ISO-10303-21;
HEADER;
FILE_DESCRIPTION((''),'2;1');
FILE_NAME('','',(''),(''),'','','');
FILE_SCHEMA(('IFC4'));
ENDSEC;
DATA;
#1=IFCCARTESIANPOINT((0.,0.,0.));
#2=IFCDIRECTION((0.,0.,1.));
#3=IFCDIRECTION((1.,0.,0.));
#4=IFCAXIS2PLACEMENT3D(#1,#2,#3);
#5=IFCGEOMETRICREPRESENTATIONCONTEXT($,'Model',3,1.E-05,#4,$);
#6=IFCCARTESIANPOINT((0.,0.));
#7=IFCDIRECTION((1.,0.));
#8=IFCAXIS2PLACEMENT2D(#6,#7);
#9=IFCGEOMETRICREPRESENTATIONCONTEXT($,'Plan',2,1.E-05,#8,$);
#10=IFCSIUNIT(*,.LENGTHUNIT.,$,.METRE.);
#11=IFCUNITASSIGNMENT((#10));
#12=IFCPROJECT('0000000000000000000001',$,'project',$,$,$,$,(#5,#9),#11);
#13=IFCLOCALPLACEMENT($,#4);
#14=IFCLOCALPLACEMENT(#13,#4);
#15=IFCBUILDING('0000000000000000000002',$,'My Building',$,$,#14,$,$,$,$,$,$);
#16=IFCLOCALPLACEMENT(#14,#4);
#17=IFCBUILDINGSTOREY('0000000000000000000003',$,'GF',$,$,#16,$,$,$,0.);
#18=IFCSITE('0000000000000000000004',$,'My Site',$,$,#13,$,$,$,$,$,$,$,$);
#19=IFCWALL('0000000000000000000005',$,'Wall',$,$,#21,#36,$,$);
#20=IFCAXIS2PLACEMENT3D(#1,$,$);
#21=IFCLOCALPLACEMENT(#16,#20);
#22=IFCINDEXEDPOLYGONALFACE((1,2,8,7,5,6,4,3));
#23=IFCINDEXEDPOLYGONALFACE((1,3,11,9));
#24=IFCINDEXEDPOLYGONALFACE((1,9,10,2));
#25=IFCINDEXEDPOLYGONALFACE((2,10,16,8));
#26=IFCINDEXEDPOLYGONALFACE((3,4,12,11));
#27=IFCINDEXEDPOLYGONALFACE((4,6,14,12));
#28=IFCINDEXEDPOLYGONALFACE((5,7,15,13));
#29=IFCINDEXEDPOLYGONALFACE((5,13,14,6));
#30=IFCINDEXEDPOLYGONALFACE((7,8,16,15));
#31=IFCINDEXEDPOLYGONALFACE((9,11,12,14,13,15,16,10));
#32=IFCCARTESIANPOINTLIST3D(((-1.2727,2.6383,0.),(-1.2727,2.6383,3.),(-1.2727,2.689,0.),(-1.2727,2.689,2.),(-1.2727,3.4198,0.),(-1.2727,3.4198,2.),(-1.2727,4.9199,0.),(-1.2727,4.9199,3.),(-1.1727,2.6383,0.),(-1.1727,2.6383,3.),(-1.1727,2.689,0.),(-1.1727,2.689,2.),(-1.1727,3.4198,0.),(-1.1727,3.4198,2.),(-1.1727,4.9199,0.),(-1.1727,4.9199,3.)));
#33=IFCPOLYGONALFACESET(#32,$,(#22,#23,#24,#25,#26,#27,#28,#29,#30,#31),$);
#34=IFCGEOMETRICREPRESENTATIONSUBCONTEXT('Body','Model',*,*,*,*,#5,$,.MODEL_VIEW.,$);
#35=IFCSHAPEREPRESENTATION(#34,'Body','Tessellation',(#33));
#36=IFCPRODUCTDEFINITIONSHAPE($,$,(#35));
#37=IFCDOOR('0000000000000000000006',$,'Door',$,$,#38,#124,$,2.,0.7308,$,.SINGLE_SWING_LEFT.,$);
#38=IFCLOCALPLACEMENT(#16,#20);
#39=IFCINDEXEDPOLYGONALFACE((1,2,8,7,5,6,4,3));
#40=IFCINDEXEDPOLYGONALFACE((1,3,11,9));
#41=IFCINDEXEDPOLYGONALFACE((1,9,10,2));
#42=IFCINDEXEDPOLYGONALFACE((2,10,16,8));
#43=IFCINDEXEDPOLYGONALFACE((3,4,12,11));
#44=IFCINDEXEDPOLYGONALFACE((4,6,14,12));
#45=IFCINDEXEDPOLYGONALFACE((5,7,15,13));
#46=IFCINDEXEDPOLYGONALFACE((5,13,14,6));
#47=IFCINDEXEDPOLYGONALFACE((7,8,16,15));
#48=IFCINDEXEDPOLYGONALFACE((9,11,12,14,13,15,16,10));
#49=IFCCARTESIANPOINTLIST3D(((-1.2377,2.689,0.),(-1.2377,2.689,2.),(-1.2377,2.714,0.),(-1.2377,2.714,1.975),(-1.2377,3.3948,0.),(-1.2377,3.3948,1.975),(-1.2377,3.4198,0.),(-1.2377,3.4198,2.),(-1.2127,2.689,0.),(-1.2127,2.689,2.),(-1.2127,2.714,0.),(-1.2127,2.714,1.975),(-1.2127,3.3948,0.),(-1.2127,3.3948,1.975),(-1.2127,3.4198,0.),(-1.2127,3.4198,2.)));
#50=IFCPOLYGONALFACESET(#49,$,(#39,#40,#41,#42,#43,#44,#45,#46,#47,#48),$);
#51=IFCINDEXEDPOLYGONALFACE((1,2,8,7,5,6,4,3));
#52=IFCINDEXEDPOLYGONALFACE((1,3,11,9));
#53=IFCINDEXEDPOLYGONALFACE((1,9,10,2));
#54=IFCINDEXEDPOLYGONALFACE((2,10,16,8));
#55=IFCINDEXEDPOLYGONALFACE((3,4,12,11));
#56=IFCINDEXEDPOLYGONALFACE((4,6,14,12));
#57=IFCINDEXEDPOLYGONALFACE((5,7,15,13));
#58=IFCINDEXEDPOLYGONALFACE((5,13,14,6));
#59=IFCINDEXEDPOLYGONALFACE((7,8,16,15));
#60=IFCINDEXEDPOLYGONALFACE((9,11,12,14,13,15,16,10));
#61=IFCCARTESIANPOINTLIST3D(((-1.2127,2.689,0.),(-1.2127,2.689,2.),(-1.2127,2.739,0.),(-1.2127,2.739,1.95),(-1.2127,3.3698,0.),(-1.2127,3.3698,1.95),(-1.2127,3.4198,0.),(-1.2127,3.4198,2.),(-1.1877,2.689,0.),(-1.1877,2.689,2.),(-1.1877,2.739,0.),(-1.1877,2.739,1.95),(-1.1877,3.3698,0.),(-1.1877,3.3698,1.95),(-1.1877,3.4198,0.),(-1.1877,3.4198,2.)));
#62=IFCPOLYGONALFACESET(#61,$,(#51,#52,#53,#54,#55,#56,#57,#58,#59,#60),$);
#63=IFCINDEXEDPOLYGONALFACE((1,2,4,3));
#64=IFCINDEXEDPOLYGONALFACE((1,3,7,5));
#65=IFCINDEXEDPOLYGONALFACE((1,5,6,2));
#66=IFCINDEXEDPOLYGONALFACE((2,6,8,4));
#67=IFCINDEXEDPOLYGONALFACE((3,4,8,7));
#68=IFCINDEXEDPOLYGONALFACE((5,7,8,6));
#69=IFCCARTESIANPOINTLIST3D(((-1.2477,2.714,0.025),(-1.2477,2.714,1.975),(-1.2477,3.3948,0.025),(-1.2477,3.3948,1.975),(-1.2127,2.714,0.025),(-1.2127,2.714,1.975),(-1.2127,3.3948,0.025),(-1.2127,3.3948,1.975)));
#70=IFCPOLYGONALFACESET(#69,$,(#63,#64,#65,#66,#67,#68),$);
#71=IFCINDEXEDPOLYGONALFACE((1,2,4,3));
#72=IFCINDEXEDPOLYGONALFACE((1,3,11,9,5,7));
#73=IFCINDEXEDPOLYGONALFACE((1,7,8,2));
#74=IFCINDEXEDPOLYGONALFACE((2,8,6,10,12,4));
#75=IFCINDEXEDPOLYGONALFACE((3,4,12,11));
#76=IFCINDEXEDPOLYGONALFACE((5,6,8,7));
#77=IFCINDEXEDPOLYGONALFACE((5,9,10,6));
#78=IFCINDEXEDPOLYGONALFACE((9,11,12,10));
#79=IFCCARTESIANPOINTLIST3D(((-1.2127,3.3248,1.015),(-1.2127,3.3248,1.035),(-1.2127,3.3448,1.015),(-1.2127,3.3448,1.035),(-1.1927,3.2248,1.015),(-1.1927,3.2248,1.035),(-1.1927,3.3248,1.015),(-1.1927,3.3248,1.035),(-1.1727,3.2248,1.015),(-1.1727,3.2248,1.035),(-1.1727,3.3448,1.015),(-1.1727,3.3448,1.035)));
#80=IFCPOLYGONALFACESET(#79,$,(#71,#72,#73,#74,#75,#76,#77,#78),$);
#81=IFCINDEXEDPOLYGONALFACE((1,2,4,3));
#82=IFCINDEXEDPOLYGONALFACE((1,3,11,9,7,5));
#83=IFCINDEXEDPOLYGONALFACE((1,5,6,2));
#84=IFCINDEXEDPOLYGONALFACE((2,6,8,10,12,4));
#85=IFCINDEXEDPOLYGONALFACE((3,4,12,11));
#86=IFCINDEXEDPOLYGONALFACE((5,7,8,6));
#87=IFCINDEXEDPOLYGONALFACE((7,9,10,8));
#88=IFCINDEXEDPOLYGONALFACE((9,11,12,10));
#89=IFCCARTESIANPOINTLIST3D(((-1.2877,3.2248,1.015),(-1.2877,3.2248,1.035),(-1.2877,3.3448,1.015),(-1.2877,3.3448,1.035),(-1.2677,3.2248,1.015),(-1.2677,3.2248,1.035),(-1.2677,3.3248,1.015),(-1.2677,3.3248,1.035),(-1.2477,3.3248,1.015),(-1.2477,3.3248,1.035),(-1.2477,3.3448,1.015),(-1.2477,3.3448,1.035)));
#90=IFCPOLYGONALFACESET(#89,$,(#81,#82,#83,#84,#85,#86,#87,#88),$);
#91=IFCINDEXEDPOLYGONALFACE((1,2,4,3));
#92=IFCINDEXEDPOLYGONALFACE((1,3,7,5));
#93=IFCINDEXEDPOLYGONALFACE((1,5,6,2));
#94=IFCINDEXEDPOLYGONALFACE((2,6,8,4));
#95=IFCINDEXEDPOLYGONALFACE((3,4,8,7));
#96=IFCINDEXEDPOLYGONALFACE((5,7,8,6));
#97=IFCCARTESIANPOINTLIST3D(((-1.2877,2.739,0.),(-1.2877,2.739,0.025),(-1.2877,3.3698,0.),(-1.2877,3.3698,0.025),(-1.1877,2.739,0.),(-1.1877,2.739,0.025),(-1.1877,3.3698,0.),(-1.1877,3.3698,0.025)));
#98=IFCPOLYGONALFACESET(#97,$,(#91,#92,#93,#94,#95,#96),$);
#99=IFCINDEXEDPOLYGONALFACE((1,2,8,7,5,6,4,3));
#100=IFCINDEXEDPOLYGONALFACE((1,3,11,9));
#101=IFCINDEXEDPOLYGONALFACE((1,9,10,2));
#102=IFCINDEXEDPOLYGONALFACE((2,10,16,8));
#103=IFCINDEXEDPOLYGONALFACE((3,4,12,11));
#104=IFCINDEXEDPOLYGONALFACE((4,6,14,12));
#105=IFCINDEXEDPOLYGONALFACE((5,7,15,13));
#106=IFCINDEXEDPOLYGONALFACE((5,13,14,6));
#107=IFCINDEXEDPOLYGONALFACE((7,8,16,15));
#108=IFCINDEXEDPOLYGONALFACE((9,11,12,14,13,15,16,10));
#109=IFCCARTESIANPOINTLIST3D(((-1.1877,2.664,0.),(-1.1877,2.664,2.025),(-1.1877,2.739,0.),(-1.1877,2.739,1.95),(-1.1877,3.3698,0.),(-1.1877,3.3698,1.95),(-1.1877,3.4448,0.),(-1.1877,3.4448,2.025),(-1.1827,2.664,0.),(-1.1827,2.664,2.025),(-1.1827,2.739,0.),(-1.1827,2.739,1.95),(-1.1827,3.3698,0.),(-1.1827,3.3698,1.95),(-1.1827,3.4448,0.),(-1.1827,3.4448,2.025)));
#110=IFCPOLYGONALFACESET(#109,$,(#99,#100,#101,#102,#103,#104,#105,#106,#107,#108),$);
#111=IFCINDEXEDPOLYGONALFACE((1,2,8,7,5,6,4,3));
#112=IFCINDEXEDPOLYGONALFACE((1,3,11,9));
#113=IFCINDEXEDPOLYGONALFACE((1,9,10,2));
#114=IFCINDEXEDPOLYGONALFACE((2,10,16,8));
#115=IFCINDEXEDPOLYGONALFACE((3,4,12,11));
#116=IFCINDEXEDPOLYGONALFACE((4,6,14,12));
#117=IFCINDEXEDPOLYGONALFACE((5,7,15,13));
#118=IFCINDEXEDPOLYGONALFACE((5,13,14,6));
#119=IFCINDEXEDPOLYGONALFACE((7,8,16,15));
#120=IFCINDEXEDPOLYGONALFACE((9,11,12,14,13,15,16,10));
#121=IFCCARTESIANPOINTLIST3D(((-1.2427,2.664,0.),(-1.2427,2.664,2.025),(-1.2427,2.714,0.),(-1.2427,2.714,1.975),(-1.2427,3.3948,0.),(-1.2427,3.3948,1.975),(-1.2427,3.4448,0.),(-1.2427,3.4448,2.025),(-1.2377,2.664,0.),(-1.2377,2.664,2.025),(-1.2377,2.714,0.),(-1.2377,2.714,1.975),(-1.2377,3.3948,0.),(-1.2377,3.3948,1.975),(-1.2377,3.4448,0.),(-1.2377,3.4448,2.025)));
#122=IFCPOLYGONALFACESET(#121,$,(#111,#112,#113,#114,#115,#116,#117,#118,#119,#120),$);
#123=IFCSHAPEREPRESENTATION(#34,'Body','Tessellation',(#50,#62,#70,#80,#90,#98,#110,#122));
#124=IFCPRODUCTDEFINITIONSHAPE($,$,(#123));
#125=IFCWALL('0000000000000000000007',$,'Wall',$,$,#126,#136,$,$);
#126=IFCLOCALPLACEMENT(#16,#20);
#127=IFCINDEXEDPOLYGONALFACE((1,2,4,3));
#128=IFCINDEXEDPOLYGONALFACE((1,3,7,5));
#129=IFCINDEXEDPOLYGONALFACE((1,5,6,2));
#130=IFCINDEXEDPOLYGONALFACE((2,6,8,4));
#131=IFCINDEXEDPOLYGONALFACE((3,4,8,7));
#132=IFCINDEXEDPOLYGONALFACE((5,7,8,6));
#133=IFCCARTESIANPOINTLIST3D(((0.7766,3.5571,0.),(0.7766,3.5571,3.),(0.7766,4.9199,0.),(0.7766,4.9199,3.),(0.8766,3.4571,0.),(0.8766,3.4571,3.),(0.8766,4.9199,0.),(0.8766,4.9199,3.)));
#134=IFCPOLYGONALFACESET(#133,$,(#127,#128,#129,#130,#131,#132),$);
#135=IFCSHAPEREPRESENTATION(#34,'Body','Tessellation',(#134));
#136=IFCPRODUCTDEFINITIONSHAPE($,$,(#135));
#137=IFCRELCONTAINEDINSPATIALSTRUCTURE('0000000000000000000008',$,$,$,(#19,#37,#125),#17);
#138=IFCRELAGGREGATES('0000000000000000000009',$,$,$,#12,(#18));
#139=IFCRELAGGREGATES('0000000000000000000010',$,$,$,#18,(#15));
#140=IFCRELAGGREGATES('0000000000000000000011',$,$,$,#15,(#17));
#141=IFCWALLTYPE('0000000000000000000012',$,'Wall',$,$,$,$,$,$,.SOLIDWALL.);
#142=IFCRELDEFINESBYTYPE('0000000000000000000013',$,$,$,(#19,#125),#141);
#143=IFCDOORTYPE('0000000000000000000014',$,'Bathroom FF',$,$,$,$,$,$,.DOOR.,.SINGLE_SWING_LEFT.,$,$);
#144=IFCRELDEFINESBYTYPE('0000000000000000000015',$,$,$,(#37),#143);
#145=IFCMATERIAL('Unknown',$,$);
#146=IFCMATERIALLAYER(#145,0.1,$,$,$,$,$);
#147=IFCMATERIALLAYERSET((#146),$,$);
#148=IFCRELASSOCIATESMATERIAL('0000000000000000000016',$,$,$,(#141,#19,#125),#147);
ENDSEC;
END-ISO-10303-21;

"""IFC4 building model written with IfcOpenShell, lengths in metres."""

from ifc_helpers import new_model, entity, si_unit, frame, origin_with_axes, origin_2d_with_axis, place, context, subcontext, project, spatial, line, indexed_curve, outline, extrude, shape, source, transform, mapped, material, layer, layer_set, layer_usage, type_object, type_shapes, element, fill, save


model = new_model("IFC4")

# Units and contexts
model_context = context("Model", 3, precision=1e-05, world=origin_with_axes())
plan_context = context("Plan", 2, precision=1e-05, world=origin_2d_with_axis())
body_context_1 = subcontext(model_context, "Body", "Model", "MODEL_VIEW")
body_context_2 = subcontext(plan_context, "Body", "Plan", "PLAN_VIEW")
ifc_project = project(units=[si_unit("LENGTHUNIT", "METRE")], contexts=[model_context, plan_context])

# Site, building, storey
site_placement = place(None, origin_with_axes())
site = spatial("IfcSite", under=ifc_project, at=site_placement, Name="My Site")
building_placement = place(site_placement, origin_with_axes())
building = spatial("IfcBuilding", under=site, at=building_placement, Name="My Building")
storey_placement = place(building_placement, origin_with_axes())
storey = spatial("IfcBuildingStorey", under=building, at=storey_placement, Name="GF", Elevation=0.0)

# Shared definitions
ifc_material = material(Name="Unknown")

# Shared definitions
ifc_layer_1 = layer(ifc_material, 0.1)
ifc_layer_set_1 = layer_set([ifc_layer_1])
wall_type = type_object("IfcWallType", Name="Wall", PredefinedType="SOLIDWALL", material=ifc_layer_set_1)

# Wall, opening, door
ifc_layer_usage_1 = layer_usage(ifc_layer_set_1, "AXIS2", "POSITIVE", 0.0)
wall_1_placement = place(storey_placement, frame((-1.1727, 2.6383, 0.0), z_axis=(0.0, 0.0, 1.0), x_axis=(0.0, 1.0, 0.0)))
wall_1 = element("IfcWall", 1, at=wall_1_placement, inside=storey, type_object=wall_type, material=ifc_layer_usage_1, Name="Wall", context=body_context_1, shape_type="SweptSolid", body=[
    extrude(outline(indexed_curve([(0.0, 0.0), (0.0, 0.1), (2.2816, 0.1), (2.2816, 0.0)], segments=[line(1, 2, 3, 4, 1)])), origin_with_axes(), (0.0, 0.0, 1.0), 3.0),
])
shared_shape_1 = source(origin_with_axes(), body_context_1, "Body", "SweptSolid", [
    extrude(outline(indexed_curve([(0.0, 0.0), (0.7308, 0.0), (0.7308, 2.0), (0.0, 2.0)], segments=[line(1, 2, 3, 4, 1)])), frame((0.0, -0.6, 0.0), z_axis=(0.0, -1.0, 0.0), x_axis=(1.0, 0.0, 0.0)), (0.0, 0.0, -1.0), 1.2),
])
opening_1_placement = place(wall_1_placement, frame((0.0507, 0.015, 0.0), z_axis=(0.0, 0.0, 1.0), x_axis=(1.0, 0.0, 0.0)))
opening_1 = element("IfcOpeningElement", 2, at=opening_1_placement, cuts=wall_1, PredefinedType="OPENING", context=body_context_1, shape_type="MappedRepresentation", body=[
    mapped(shared_shape_1, transform((0.0, 0.0, 0.0), x_axis=(1.0, 0.0, 0.0), y_axis=(0.0, 1.0, 0.0), z_axis=(0.0, 0.0, 1.0), scale=1.0)),
])
door_type_1 = type_object("IfcDoorType", Name="Bathroom FF", OperationType="SINGLE_SWING_LEFT", PredefinedType="DOOR")
shared_shape_2 = source(origin_with_axes(), body_context_1, "Body", "SweptSolid", [
    extrude(outline(indexed_curve([(0.0, 0.0), (0.0, 2.0), (0.7308, 2.0), (0.7308, 0.0), (0.7058, 0.0), (0.7058, 1.975), (0.025, 1.975), (0.025, 0.0)], segments=[line(1, 2, 3, 4, 5, 6, 7, 8, 1)])), frame((0.0, 0.025, 0.0), z_axis=(0.0, -1.0, 0.0), x_axis=(1.0, 0.0, 0.0)), (0.0, 0.0, -1.0), 0.025),
    extrude(outline(indexed_curve([(0.0, 0.0), (0.0, 2.0), (0.7308, 2.0), (0.7308, 0.0), (0.6808, 0.0), (0.6808, 1.95), (0.05, 1.95), (0.05, 0.0)], segments=[line(1, 2, 3, 4, 5, 6, 7, 8, 1)])), frame((0.0, 0.0, 0.0), z_axis=(0.0, -1.0, 0.0), x_axis=(1.0, 0.0, 0.0)), (0.0, 0.0, -1.0), 0.025),
    extrude(outline(indexed_curve([(0.0, 0.0), (0.6808, 0.0), (0.6808, 0.035), (0.0, 0.035)], segments=[line(1, 2, 3, 4, 1)])), frame((0.025, 0.025, 0.025), z_axis=(0.0, 0.0, 1.0), x_axis=(1.0, 0.0, 0.0)), (0.0, 0.0, 1.0), 1.95),
    extrude(outline(indexed_curve([(0.0, 0.0), (0.0, -0.04), (-0.12, -0.04), (-0.12, -0.02), (-0.02, -0.02), (-0.02, 0.0)], segments=[line(1, 2, 3, 4, 5, 6, 1)])), frame((0.6558, 0.025, 1.015), z_axis=(0.0, 0.0, 1.0), x_axis=(1.0, 0.0, 0.0)), (0.0, 0.0, 1.0), 0.02),
    extrude(outline(indexed_curve([(0.0, 0.0), (0.0, 0.04), (-0.12, 0.04), (-0.12, 0.02), (-0.02, 0.02), (-0.02, 0.0)], segments=[line(1, 2, 3, 4, 5, 6, 1)])), frame((0.6558, 0.06, 1.015), z_axis=(0.0, 0.0, 1.0), x_axis=(1.0, 0.0, 0.0)), (0.0, 0.0, 1.0), 0.02),
    extrude(outline(indexed_curve([(0.0, 0.0), (0.6308, 0.0), (0.6308, 0.1), (0.0, 0.1)], segments=[line(1, 2, 3, 4, 1)])), frame((0.05, 0.0, 0.0), z_axis=(0.0, 0.0, 1.0), x_axis=(1.0, 0.0, 0.0)), (0.0, 0.0, 1.0), 0.025),
    extrude(outline(indexed_curve([(0.0, 0.0), (0.0, 2.025), (0.7808, 2.025), (0.7808, 0.0), (0.7058, 0.0), (0.7058, 1.95), (0.075, 1.95), (0.075, 0.0)], segments=[line(1, 2, 3, 4, 5, 6, 7, 8, 1)])), frame((-0.025, -0.005, 0.0), z_axis=(0.0, -1.0, 0.0), x_axis=(1.0, 0.0, 0.0)), (0.0, 0.0, -1.0), 0.005),
    extrude(outline(indexed_curve([(0.0, 0.0), (0.0, 2.025), (0.7808, 2.025), (0.7808, 0.0), (0.7308, 0.0), (0.7308, 1.975), (0.05, 1.975), (0.05, 0.0)], segments=[line(1, 2, 3, 4, 5, 6, 7, 8, 1)])), frame((-0.025, 0.05, 0.0), z_axis=(0.0, -1.0, 0.0), x_axis=(1.0, 0.0, 0.0)), (0.0, 0.0, -1.0), 0.005),
])
shared_shape_3 = source(origin_with_axes(), body_context_2, "Body", "Curve2D", [
    entity("IfcIndexedPolyCurve", entity("IfcCartesianPointList2D", [[0.0, 0.0], [0.0, 0.05], [0.025, 0.05], [0.025, 0.025], [0.05, 0.025], [0.05, 0.0]]), [entity("IfcLineIndex", [1, 2, 3, 4, 5, 6, 1])]),
    entity("IfcIndexedPolyCurve", entity("IfcCartesianPointList2D", [[0.7308, 0.0], [0.7308, 0.05], [0.7058, 0.05], [0.7058, 0.025], [0.6808, 0.025], [0.6808, 0.0]]), [entity("IfcLineIndex", [1, 2, 3, 4, 5, 6, 1])]),
    entity("IfcTrimmedCurve", entity("IfcEllipse", entity("IfcAxis2Placement2D", entity("IfcCartesianPoint", [0.06, 0.05]), entity("IfcDirection", [1.0, 0.0])), 0.6458, 0.6808), [entity("IfcCartesianPoint", [0.7058, 0.05])], [entity("IfcCartesianPoint", [0.06, 0.7308])], True, "CARTESIAN"),
    entity("IfcIndexedPolyCurve", entity("IfcCartesianPointList2D", [[0.025, 0.05], [0.06, 0.05], [0.06, 0.7308], [0.025, 0.7308]]), [entity("IfcLineIndex", [1, 2, 3, 4, 1])]),
])
type_shapes(door_type_1, [shared_shape_2, shared_shape_3])
door_1_placement = place(opening_1_placement, frame((0.0, 0.0, 0.0), z_axis=(0.0, 0.0, 1.0), x_axis=(1.0, 0.0, 0.0)))
door_1 = element("IfcDoor", 3, at=door_1_placement, inside=storey, type_object=door_type_1, Name="Door", OperationType="SINGLE_SWING_LEFT", OverallHeight=2.0, OverallWidth=0.7308, shapes=[
    shape(body_context_1, "Body", "MappedRepresentation", [mapped(shared_shape_2, transform((0.0, 0.0, 0.0), x_axis=(1.0, 0.0, 0.0), y_axis=(0.0, 1.0, 0.0), z_axis=(0.0, 0.0, 1.0), scale=1.0))]),
    shape(body_context_2, "Body", "MappedRepresentation", [mapped(shared_shape_3, transform((0.0, 0.0, 0.0), x_axis=(1.0, 0.0, 0.0), y_axis=(0.0, 1.0, 0.0), z_axis=(0.0, 0.0, 1.0), scale=1.0))]),
])
fill(opening_1, door_1)

# Wall
ifc_layer_usage_2 = layer_usage(ifc_layer_set_1, "AXIS2", "POSITIVE", 0.0)
wall_2_placement = place(storey_placement, frame((0.7766, 5.0199, 0.0), z_axis=(0.0, 0.0, 1.0), x_axis=(0.0, -1.0, 0.0)))
element("IfcWall", 4, at=wall_2_placement, inside=storey, type_object=wall_type, material=ifc_layer_usage_2, Name="Wall", context=body_context_1, shape_type="SweptSolid", body=[
    extrude(outline(indexed_curve([(0.1, 0.0), (0.1, 0.1), (1.5628, 0.1), (1.4628, 0.0)], segments=[line(1, 2, 3, 4, 1)])), origin_with_axes(), (0.0, 0.0, 1.0), 3.0),
])

save(model, "model.ifc")
